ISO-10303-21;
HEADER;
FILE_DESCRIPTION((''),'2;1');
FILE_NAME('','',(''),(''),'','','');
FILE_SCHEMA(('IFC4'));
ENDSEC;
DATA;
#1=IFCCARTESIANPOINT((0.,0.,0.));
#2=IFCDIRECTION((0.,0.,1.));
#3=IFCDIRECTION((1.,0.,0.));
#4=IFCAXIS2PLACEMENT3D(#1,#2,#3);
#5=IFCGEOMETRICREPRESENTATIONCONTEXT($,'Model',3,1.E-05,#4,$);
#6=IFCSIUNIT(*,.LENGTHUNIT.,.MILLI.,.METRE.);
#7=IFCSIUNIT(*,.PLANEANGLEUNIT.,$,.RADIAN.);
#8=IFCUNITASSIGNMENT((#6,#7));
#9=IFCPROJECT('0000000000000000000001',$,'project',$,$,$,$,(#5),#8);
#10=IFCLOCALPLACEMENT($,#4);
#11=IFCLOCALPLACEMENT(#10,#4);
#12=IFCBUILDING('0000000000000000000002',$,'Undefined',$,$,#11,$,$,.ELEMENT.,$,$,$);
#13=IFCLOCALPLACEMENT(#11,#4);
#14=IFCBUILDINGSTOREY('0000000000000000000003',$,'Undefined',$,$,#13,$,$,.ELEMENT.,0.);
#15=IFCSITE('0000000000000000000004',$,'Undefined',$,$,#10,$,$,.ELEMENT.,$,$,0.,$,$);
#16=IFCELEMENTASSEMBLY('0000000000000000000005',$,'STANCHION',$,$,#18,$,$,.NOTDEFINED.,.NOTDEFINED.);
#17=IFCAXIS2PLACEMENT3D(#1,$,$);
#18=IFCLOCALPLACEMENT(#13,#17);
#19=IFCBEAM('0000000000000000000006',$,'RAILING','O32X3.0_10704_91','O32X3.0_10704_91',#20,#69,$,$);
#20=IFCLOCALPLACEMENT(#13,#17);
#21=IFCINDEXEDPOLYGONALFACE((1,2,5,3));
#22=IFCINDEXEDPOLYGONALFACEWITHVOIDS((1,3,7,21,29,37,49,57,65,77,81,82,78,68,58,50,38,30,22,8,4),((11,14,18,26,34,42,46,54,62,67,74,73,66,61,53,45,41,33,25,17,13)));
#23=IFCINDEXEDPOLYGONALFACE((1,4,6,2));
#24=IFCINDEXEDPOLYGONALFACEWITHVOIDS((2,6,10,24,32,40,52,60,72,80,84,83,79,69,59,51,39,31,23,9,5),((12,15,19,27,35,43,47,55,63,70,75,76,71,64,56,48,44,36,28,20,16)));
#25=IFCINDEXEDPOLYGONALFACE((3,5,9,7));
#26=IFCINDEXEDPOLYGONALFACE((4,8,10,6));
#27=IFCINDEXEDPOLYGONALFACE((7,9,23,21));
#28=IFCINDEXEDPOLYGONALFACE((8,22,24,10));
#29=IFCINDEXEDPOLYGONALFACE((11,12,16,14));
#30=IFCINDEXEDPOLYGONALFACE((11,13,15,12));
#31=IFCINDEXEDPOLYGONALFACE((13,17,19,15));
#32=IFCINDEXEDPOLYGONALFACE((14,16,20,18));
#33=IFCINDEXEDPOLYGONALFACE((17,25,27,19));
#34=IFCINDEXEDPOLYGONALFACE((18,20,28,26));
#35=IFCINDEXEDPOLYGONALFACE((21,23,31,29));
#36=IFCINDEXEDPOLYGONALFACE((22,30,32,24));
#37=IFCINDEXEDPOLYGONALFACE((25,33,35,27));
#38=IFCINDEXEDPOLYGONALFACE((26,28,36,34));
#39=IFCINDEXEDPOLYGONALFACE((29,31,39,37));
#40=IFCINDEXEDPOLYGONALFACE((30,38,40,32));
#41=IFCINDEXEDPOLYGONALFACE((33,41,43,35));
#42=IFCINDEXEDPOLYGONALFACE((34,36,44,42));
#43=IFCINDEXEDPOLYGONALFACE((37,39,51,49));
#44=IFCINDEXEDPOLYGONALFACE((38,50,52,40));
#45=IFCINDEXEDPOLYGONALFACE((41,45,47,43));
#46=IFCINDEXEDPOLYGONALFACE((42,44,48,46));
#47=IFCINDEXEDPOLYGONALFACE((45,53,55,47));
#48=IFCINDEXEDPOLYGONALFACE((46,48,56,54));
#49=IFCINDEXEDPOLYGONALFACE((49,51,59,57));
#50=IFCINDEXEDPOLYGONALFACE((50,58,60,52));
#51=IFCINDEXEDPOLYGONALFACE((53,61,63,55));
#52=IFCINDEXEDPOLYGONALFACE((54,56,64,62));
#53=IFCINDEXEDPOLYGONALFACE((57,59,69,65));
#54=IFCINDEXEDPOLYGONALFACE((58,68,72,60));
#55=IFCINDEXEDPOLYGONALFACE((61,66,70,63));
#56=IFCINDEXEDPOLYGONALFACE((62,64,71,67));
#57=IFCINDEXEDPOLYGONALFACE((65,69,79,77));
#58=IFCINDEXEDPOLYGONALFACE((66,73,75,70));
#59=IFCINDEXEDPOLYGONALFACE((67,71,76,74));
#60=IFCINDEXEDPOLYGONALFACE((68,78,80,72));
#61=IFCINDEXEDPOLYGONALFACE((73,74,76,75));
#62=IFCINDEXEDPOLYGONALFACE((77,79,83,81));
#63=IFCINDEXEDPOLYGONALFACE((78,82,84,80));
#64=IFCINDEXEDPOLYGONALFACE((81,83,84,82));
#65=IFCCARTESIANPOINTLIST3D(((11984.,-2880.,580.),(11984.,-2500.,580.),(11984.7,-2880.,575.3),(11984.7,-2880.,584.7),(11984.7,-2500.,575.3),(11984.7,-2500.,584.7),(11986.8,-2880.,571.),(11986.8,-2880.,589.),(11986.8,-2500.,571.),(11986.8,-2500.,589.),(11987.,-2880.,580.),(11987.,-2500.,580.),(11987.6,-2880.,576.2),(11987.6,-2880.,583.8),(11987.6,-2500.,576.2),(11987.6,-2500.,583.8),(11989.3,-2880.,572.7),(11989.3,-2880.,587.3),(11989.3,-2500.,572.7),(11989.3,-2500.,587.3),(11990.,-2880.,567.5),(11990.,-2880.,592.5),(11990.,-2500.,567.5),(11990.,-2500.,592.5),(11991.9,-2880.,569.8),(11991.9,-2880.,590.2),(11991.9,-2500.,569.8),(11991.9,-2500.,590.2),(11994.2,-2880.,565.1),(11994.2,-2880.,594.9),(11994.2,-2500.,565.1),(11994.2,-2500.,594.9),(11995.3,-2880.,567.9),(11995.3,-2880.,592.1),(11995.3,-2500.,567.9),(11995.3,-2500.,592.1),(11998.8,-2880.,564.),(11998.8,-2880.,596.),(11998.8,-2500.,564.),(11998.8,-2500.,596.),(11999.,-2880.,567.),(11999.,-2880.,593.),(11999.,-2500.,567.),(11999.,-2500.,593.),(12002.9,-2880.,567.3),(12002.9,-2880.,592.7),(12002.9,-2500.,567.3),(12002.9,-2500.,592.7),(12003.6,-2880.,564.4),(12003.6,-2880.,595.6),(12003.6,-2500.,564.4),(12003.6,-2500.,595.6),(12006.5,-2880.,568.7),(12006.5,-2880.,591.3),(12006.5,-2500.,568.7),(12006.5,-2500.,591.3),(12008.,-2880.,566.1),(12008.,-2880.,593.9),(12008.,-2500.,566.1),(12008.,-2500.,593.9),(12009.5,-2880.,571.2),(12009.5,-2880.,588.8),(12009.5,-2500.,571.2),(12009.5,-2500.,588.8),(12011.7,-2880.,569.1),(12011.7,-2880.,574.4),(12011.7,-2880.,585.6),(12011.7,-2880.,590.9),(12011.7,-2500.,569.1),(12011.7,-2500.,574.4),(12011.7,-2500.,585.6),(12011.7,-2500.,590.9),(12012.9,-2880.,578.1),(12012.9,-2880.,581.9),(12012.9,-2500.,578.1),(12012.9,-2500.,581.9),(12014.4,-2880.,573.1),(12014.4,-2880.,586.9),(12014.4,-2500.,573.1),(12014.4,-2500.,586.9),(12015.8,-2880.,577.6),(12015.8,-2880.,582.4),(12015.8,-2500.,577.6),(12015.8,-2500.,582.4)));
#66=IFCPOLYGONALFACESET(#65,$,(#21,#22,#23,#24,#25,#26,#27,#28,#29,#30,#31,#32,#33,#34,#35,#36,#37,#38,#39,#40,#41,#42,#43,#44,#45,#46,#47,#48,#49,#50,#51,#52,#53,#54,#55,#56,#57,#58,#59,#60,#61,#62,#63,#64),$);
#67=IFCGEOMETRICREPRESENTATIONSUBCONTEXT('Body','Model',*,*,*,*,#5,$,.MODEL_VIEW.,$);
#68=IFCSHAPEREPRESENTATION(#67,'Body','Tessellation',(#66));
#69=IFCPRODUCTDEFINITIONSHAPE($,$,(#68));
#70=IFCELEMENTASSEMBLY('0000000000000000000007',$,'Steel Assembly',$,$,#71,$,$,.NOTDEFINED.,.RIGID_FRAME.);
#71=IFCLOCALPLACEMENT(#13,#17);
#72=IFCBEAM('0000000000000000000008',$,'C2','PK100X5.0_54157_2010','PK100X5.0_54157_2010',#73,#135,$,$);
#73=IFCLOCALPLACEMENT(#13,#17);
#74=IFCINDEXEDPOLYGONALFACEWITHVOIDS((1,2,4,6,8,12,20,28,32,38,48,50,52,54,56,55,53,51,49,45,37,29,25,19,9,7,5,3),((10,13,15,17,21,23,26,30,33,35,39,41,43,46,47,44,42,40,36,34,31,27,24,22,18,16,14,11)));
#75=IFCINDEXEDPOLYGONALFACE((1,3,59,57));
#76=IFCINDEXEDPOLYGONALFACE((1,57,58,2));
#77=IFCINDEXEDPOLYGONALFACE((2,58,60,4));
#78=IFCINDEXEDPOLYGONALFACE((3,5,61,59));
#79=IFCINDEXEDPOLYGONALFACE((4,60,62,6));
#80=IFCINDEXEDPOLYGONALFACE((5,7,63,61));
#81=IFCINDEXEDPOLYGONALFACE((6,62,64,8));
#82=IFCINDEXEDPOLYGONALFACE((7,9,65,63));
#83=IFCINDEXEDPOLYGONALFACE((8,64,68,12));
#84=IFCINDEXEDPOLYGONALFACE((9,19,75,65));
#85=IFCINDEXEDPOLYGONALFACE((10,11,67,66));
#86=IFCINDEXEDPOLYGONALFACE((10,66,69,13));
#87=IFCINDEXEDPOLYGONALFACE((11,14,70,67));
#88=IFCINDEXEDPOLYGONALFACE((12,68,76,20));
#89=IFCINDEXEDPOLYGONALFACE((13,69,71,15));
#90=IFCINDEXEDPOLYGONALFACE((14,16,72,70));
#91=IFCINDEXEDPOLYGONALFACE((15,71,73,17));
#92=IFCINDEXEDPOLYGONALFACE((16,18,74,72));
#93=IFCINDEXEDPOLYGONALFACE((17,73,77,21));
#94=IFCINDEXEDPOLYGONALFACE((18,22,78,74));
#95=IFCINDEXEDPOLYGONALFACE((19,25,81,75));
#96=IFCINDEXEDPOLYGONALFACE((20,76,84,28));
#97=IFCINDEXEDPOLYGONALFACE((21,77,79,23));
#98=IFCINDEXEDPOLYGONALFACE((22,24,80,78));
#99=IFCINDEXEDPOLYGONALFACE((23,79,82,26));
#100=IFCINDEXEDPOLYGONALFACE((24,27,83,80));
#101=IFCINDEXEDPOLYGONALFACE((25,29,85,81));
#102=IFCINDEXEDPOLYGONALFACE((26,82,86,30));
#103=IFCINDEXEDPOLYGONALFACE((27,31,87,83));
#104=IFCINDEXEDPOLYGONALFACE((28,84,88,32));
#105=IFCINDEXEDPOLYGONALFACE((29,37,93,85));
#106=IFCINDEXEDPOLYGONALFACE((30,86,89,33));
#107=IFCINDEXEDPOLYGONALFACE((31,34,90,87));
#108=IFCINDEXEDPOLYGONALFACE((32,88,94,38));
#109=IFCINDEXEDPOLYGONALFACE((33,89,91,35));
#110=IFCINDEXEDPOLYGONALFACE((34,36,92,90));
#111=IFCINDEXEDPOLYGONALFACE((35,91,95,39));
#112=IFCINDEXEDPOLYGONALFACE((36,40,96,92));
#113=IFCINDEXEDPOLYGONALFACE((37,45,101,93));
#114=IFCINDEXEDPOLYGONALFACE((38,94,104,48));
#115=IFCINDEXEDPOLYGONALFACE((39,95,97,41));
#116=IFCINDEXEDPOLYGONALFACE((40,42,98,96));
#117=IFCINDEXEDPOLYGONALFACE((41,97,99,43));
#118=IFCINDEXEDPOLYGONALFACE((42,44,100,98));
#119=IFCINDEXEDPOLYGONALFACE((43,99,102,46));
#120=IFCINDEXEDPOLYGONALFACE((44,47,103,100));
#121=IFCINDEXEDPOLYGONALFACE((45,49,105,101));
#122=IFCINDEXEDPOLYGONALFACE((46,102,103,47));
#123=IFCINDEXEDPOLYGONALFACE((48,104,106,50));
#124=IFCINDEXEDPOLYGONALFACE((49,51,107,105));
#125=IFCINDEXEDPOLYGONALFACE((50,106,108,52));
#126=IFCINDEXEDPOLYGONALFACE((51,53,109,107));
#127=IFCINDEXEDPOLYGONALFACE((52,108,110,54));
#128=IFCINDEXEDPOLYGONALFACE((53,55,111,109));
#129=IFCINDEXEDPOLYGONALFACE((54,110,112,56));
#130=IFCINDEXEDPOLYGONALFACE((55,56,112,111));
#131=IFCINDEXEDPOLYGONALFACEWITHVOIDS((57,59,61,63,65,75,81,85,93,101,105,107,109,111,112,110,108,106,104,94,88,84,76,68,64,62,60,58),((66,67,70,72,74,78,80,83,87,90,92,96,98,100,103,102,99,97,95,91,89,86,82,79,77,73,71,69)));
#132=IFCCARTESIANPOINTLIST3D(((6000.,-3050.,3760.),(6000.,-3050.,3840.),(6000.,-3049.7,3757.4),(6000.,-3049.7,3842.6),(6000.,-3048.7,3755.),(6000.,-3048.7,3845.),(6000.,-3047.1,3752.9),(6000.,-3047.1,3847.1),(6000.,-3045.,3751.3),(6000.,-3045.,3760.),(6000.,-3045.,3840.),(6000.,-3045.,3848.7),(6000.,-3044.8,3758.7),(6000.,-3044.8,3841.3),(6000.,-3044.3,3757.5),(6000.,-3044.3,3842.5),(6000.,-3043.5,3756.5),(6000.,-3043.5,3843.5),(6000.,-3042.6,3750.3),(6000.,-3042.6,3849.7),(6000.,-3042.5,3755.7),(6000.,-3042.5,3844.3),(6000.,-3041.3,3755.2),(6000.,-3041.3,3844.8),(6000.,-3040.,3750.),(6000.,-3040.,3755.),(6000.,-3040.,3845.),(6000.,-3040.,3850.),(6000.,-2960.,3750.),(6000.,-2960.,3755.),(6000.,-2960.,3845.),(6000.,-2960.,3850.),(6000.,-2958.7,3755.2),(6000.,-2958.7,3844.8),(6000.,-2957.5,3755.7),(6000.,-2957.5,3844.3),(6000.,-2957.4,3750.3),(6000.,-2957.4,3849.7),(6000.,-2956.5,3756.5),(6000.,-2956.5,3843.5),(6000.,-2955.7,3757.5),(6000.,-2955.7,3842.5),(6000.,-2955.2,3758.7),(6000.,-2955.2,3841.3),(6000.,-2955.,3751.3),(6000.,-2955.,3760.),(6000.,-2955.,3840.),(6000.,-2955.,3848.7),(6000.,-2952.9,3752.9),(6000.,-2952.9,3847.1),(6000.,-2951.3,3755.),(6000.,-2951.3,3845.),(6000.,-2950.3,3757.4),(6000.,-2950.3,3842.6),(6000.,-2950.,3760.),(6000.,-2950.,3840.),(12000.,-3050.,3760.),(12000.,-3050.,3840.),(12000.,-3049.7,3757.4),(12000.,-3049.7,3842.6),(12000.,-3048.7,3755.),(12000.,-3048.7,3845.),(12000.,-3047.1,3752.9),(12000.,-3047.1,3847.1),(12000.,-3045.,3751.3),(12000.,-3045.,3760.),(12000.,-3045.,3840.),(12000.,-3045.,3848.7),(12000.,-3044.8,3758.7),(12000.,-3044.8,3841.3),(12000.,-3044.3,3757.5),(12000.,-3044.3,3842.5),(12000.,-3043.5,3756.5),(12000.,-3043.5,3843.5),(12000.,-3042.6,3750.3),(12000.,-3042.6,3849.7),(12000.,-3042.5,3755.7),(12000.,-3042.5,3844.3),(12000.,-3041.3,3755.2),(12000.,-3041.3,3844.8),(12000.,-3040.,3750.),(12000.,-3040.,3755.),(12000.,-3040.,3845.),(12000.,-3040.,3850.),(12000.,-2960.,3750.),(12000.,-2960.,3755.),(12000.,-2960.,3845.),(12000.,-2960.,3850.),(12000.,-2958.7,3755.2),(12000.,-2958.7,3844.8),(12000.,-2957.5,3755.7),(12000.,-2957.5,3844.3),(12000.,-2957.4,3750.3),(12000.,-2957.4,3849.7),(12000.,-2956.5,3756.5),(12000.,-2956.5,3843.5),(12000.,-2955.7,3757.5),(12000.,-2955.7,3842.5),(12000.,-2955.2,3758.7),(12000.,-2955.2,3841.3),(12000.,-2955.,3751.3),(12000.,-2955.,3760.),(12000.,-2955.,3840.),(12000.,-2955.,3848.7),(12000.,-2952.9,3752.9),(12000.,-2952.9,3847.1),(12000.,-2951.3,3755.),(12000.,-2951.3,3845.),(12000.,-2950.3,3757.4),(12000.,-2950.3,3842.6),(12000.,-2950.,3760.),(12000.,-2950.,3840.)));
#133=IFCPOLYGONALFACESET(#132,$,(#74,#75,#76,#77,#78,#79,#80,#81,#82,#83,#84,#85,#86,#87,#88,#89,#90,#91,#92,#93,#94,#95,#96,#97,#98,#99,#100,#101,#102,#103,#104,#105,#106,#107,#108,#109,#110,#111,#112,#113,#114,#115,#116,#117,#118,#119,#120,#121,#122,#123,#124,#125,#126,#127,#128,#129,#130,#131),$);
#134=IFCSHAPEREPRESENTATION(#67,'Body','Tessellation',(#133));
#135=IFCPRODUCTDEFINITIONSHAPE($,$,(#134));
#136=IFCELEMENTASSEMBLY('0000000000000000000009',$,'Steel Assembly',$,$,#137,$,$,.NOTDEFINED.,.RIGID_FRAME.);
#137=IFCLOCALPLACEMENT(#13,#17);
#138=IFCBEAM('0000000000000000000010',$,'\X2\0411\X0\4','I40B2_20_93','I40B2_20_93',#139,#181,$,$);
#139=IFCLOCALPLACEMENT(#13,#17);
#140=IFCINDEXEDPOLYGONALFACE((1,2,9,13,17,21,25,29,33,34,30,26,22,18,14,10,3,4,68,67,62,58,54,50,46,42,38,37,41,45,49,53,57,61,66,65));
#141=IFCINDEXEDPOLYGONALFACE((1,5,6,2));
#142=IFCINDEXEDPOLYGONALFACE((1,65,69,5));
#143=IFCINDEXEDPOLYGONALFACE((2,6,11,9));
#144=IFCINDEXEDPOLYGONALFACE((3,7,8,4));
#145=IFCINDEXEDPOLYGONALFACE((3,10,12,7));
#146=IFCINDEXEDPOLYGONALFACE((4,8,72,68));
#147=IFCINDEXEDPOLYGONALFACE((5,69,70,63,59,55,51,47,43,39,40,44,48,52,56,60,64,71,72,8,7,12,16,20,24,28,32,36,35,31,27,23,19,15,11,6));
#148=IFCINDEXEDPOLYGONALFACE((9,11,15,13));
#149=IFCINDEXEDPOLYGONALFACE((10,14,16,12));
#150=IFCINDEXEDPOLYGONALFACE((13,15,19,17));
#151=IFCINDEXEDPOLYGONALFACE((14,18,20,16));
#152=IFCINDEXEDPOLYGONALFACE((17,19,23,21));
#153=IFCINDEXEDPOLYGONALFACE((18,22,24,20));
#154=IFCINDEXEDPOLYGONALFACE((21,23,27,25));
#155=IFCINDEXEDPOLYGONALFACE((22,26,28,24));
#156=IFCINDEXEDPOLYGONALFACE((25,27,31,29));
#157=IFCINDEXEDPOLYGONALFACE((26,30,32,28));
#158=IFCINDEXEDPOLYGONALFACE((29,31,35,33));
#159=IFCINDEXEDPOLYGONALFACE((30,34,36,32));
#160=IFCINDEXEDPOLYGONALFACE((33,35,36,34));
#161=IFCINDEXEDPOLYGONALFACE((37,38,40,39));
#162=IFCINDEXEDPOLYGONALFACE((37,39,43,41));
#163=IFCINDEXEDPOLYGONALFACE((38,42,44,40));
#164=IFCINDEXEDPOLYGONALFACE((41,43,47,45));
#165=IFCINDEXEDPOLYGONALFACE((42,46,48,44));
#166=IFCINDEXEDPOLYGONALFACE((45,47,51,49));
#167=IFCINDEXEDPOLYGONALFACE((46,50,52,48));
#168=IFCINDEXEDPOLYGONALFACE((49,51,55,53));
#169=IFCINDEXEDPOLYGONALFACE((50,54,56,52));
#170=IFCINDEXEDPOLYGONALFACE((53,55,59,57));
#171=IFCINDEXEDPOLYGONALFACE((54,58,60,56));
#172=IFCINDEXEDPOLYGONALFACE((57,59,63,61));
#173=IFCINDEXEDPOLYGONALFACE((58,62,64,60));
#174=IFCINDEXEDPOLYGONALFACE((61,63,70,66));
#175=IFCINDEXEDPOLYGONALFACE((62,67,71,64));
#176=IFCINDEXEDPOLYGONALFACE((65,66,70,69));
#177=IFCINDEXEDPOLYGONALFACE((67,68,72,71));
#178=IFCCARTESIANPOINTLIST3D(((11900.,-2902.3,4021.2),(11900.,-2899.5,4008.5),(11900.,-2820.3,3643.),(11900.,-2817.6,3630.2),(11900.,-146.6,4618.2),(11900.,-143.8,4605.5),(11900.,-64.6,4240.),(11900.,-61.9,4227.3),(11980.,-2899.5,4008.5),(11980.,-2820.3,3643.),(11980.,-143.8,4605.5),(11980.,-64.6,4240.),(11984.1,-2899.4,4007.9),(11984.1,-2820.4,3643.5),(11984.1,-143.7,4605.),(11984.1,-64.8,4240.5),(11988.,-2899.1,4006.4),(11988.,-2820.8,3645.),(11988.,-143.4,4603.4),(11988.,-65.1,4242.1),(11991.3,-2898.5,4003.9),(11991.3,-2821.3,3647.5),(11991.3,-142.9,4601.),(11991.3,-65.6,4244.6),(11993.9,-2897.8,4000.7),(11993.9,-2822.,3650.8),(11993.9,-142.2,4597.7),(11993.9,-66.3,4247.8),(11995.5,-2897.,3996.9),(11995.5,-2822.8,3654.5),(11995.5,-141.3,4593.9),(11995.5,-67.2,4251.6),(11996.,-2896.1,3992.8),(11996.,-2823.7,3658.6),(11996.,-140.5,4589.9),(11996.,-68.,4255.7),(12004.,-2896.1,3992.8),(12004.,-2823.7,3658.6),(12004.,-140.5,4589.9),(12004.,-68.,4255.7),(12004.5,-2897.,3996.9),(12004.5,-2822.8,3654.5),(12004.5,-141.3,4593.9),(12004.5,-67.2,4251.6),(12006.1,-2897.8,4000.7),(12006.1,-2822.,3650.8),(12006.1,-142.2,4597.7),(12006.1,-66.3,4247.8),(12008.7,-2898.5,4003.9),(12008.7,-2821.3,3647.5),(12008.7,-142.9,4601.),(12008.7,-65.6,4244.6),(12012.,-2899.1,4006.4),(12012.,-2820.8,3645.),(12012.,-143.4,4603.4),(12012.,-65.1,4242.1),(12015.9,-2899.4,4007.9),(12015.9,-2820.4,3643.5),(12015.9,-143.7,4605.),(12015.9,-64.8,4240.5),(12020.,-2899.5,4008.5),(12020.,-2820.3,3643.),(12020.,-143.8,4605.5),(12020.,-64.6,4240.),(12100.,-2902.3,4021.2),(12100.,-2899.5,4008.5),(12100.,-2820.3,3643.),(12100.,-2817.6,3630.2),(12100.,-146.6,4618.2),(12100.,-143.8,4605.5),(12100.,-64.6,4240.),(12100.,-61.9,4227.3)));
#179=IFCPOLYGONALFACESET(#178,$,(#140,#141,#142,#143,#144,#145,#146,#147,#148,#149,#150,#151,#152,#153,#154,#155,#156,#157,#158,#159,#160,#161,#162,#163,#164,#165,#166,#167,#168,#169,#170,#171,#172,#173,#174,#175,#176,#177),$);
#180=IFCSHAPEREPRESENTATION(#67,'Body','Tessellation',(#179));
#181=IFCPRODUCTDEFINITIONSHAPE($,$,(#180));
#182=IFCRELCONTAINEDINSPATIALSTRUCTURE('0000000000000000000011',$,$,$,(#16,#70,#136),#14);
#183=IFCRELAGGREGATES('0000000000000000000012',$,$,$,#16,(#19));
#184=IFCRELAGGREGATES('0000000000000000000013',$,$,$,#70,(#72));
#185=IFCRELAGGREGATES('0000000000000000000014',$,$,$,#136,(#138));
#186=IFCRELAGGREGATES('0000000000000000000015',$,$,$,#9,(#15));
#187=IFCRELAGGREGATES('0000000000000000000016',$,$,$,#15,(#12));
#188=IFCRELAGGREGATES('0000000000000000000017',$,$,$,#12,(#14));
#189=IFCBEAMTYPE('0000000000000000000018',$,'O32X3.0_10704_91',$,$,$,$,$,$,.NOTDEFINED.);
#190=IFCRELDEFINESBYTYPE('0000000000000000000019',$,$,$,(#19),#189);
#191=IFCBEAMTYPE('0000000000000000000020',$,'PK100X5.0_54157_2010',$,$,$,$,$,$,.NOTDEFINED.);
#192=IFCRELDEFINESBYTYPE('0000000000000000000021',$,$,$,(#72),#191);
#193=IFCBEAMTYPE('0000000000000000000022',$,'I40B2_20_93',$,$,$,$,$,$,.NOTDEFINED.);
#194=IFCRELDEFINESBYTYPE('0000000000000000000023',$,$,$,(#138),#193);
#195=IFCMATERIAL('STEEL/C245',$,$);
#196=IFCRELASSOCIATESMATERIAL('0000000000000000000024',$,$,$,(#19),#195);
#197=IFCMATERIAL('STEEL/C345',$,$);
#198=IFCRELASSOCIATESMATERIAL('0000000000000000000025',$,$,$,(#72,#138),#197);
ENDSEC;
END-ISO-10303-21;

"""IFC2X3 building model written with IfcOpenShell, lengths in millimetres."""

from ifc_helpers import new_model, si_unit, frame, origin_with_axes, origin_2d_with_axis, place, context, subcontext, project, spatial, hollow_rectangle, hollow_circle, i_section, extrude, material, type_object, element, aggregate, save


model = new_model("IFC2X3")

# Units and contexts
model_context = context("Model", 3, precision=1e-05, world=origin_with_axes())
body_context = subcontext(model_context, "Body", "Model", "MODEL_VIEW")
ifc_project = project(units=[si_unit("LENGTHUNIT", "METRE", prefix="MILLI"), si_unit("PLANEANGLEUNIT", "RADIAN")], contexts=[model_context])

# Site, building, storey
site_placement = place(None, origin_with_axes())
site = spatial("IfcSite", under=ifc_project, at=site_placement, Name="Undefined", CompositionType="ELEMENT", RefElevation=0.0)
building_placement = place(site_placement, origin_with_axes())
building = spatial("IfcBuilding", under=site, at=building_placement, Name="Undefined", CompositionType="ELEMENT")
storey_placement = place(building_placement, origin_with_axes())
storey = spatial("IfcBuildingStorey", under=building, at=storey_placement, Name="Undefined", CompositionType="ELEMENT", Elevation=0.0)

# Element assembly
ifc_material_1 = material(Name="STEEL/C245")
assembly_1_placement = place(storey_placement, origin_with_axes())
assembly_1 = element("IfcElementAssembly", 1, at=assembly_1_placement, inside=storey, Name="STANCHION", AssemblyPlace="NOTDEFINED", PredefinedType="NOTDEFINED")

# Beam
beam_type_1 = type_object("IfcBeamType", Name="O32X3.0_10704_91", PredefinedType="NOTDEFINED")
beam_1_placement = place(assembly_1_placement, frame((12000.0, -2880.0, 580.0), z_axis=(0.0, 0.0, -1.0), x_axis=(0.0, 1.0, 0.0)))
beam_1 = element("IfcBeam", 2, at=beam_1_placement, type_object=beam_type_1, material=ifc_material_1, Name="RAILING", Description="O32X3.0_10704_91", ObjectType="O32X3.0_10704_91", context=body_context, shape_type="SweptSolid", body=[
    extrude(hollow_circle(Radius=16.0, WallThickness=3.0, at=origin_2d_with_axis()), frame((380.0, 0.0, 0.0), z_axis=(-1.0, 0.0, 0.0), x_axis=(0.0, -1.0, 0.0)), (0.0, 0.0, 1.0), 380.0),
])
aggregate(assembly_1, [beam_1])

# Element assemblies, beams
assembly_2_placement = place(storey_placement, origin_with_axes())
assembly_2 = element("IfcElementAssembly", 3, at=assembly_2_placement, inside=storey, Name="Steel Assembly", AssemblyPlace="NOTDEFINED", PredefinedType="RIGID_FRAME")
ifc_material_2 = material(Name="STEEL/C345")
beam_type_2 = type_object("IfcBeamType", Name="PK100X5.0_54157_2010", PredefinedType="NOTDEFINED")
beam_2_placement = place(assembly_2_placement, frame((12000.0, -3000.0, 3800.0), z_axis=(0.0, 0.0, 1.0), x_axis=(-1.0, 0.0, 0.0)))
beam_2 = element("IfcBeam", 4, at=beam_2_placement, type_object=beam_type_2, material=ifc_material_2, Name="C2", Description="PK100X5.0_54157_2010", ObjectType="PK100X5.0_54157_2010", context=body_context, shape_type="SweptSolid", body=[
    extrude(hollow_rectangle(XDim=100.0, YDim=100.0, WallThickness=5.0, InnerFilletRadius=5.0, OuterFilletRadius=10.0, at=origin_2d_with_axis()), frame((6000.0, 0.0, 0.0), z_axis=(-1.0, 0.0, 0.0), x_axis=(0.0, -1.0, 0.0)), (0.0, 0.0, 1.0), 6000.0),
])
aggregate(assembly_2, [beam_2])
assembly_3_placement = place(storey_placement, origin_with_axes())
assembly_3 = element("IfcElementAssembly", 5, at=assembly_3_placement, inside=storey, Name="Steel Assembly", AssemblyPlace="NOTDEFINED", PredefinedType="RIGID_FRAME")
beam_type_3 = type_object("IfcBeamType", Name="I40B2_20_93", PredefinedType="NOTDEFINED")
beam_3_placement = place(assembly_3_placement, frame((12000.0, -2859.9, 3825.7), z_axis=(0.0, -0.211753, 0.977323), x_axis=(0.0, 0.977323, 0.211753)))
beam_3 = element("IfcBeam", 6, at=beam_3_placement, type_object=beam_type_3, material=ifc_material_2, Name="Б4", Description="I40B2_20_93", ObjectType="I40B2_20_93", context=body_context, shape_type="SweptSolid", body=[
    extrude(i_section(OverallWidth=200.0, OverallDepth=400.0, WebThickness=8.0, FlangeThickness=13.0, FilletRadius=16.0, at=origin_2d_with_axis()), frame((2819.6, 0.0, 0.0), z_axis=(-1.0, 0.0, 0.0), x_axis=(0.0, -1.0, 0.0)), (0.0, 0.0, 1.0), 2819.6),
])
aggregate(assembly_3, [beam_3])

save(model, "model.ifc")
